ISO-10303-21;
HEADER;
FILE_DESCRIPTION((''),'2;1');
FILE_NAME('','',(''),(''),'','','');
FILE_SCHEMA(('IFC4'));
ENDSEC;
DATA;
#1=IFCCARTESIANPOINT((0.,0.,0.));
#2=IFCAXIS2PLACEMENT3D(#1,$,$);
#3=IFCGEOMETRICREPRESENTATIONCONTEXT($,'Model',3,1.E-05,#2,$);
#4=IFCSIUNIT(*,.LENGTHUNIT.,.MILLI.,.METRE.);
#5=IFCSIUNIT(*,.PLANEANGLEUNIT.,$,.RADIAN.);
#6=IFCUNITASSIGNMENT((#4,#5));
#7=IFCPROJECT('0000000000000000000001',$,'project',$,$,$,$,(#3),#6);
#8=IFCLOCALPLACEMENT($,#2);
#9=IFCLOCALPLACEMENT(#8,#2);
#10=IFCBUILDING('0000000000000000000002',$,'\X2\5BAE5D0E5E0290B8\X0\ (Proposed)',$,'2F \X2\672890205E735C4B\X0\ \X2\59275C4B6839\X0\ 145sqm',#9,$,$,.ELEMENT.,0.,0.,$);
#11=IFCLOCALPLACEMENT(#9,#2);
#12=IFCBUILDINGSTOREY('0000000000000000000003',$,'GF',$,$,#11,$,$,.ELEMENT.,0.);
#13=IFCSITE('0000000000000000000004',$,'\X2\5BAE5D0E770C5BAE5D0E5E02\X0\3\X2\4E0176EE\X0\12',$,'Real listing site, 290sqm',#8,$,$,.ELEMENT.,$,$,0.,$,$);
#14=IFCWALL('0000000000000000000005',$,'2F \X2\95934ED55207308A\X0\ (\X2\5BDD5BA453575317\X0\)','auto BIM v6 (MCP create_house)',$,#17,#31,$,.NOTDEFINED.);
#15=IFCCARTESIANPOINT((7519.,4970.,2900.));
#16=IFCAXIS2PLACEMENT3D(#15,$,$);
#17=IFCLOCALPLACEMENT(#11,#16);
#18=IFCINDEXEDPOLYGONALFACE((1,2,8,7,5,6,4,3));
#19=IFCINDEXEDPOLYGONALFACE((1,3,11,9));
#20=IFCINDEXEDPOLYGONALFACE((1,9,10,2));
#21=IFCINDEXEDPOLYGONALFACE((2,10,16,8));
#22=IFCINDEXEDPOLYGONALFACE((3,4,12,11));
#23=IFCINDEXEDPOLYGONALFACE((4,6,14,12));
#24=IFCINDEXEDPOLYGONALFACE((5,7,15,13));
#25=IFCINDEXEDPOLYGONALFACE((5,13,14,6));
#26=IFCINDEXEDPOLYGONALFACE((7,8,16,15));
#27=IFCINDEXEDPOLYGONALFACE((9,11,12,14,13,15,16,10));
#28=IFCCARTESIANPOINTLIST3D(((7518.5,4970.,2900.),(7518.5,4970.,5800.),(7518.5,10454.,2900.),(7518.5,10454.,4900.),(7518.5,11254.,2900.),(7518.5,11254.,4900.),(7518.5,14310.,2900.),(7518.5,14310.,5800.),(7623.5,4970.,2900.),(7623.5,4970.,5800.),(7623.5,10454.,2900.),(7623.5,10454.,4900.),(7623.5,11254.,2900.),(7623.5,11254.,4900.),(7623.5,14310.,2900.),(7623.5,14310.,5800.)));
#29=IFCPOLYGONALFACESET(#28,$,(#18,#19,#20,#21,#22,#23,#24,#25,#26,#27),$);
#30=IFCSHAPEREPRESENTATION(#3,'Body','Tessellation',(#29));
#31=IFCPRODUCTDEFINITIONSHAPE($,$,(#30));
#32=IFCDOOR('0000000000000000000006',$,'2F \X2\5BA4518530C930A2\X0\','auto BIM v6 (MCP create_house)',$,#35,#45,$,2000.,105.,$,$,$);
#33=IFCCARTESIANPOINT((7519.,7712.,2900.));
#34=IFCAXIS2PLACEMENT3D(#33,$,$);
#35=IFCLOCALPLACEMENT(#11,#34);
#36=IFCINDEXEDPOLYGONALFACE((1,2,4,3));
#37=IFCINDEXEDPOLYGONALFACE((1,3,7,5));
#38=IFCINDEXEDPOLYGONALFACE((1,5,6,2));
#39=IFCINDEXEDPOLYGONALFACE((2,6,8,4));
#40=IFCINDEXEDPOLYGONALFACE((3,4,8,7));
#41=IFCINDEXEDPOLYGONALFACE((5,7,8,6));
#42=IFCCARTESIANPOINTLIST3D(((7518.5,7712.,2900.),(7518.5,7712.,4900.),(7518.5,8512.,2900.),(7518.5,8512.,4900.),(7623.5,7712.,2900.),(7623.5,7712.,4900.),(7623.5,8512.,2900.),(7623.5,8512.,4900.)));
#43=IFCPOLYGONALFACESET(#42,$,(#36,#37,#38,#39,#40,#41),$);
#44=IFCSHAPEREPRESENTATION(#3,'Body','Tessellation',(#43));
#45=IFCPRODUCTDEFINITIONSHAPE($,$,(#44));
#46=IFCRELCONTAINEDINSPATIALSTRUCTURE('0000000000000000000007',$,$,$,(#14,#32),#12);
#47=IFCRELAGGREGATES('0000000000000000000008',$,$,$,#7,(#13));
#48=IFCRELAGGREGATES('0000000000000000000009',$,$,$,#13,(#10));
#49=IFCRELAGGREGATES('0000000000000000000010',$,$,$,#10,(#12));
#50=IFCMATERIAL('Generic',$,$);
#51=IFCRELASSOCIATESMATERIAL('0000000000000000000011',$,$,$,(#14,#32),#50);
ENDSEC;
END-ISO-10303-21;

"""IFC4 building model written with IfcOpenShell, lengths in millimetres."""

from ifc_helpers import new_model, si_unit, frame, frame_2d, origin, place, context, project, spatial, rectangle, extrude, material, element, fill, save


model = new_model("IFC4")

# Units and contexts
model_context = context("Model", 3, precision=1e-05, world=origin())
ifc_project = project(units=[si_unit("LENGTHUNIT", "METRE", prefix="MILLI"), si_unit("PLANEANGLEUNIT", "RADIAN")], contexts=[model_context])

# Site, building, storey
site_placement = place(None, origin())
site = spatial("IfcSite", under=ifc_project, at=site_placement, Name="宮崎県宮崎市3丁目12", ObjectType="Real listing site, 290sqm", CompositionType="ELEMENT", RefElevation=0.0)
building_placement = place(site_placement, origin())
building = spatial("IfcBuilding", under=site, at=building_placement, Name="宮崎市邸 (Proposed)", ObjectType="2F 木造平屋 大屋根 145sqm", CompositionType="ELEMENT", ElevationOfRefHeight=0.0, ElevationOfTerrain=0.0)
storey_placement = place(building_placement, origin())
storey = spatial("IfcBuildingStorey", under=building, at=storey_placement, Name="GF", CompositionType="ELEMENT", Elevation=0.0)

# Shared definitions
ifc_material = material(Name="Generic")

# Wall, opening, door
wall_1_placement = place(storey_placement, frame((7519.0, 4970.0, 2900.0)))
wall_1 = element("IfcWall", 1, at=wall_1_placement, inside=storey, material=ifc_material, Name="2F 間仕切り (寝室南北)", Description="auto BIM v6 (MCP create_house)", PredefinedType="NOTDEFINED", context=model_context, shape_type="SweptSolid", body=[
    extrude(rectangle(XDim=105.0, YDim=9340.0, at=frame_2d((52.0, 4670.0))), frame((7519.0, 4970.0, 2900.0)), (0.0, 0.0, 1.0), 2900.0),
])
opening_1_placement = place(storey_placement, frame((7519.0, 7712.0, 2900.0)))
opening_1 = element("IfcOpeningElement", 2, at=opening_1_placement, cuts=wall_1, PredefinedType="NOTDEFINED", context=model_context, shape_type="SweptSolid", body=[
    extrude(rectangle(XDim=105.0, YDim=800.0, at=frame_2d((52.0, 400.0))), frame((7519.0, 7712.0, 2900.0)), (0.0, 0.0, 1.0), 2000.0),
])
door_placement = place(storey_placement, frame((7519.0, 7712.0, 2900.0)))
door = element("IfcDoor", 3, at=door_placement, inside=storey, material=ifc_material, Name="2F 室内ドア", Description="auto BIM v6 (MCP create_house)", OverallHeight=2000.0, OverallWidth=105.0, context=model_context, shape_type="SweptSolid", body=[
    extrude(rectangle(XDim=105.0, YDim=800.0, at=frame_2d((52.0, 400.0))), frame((7519.0, 7712.0, 2900.0)), (0.0, 0.0, 1.0), 2000.0),
])
fill(opening_1, door)

save(model, "model.ifc")
